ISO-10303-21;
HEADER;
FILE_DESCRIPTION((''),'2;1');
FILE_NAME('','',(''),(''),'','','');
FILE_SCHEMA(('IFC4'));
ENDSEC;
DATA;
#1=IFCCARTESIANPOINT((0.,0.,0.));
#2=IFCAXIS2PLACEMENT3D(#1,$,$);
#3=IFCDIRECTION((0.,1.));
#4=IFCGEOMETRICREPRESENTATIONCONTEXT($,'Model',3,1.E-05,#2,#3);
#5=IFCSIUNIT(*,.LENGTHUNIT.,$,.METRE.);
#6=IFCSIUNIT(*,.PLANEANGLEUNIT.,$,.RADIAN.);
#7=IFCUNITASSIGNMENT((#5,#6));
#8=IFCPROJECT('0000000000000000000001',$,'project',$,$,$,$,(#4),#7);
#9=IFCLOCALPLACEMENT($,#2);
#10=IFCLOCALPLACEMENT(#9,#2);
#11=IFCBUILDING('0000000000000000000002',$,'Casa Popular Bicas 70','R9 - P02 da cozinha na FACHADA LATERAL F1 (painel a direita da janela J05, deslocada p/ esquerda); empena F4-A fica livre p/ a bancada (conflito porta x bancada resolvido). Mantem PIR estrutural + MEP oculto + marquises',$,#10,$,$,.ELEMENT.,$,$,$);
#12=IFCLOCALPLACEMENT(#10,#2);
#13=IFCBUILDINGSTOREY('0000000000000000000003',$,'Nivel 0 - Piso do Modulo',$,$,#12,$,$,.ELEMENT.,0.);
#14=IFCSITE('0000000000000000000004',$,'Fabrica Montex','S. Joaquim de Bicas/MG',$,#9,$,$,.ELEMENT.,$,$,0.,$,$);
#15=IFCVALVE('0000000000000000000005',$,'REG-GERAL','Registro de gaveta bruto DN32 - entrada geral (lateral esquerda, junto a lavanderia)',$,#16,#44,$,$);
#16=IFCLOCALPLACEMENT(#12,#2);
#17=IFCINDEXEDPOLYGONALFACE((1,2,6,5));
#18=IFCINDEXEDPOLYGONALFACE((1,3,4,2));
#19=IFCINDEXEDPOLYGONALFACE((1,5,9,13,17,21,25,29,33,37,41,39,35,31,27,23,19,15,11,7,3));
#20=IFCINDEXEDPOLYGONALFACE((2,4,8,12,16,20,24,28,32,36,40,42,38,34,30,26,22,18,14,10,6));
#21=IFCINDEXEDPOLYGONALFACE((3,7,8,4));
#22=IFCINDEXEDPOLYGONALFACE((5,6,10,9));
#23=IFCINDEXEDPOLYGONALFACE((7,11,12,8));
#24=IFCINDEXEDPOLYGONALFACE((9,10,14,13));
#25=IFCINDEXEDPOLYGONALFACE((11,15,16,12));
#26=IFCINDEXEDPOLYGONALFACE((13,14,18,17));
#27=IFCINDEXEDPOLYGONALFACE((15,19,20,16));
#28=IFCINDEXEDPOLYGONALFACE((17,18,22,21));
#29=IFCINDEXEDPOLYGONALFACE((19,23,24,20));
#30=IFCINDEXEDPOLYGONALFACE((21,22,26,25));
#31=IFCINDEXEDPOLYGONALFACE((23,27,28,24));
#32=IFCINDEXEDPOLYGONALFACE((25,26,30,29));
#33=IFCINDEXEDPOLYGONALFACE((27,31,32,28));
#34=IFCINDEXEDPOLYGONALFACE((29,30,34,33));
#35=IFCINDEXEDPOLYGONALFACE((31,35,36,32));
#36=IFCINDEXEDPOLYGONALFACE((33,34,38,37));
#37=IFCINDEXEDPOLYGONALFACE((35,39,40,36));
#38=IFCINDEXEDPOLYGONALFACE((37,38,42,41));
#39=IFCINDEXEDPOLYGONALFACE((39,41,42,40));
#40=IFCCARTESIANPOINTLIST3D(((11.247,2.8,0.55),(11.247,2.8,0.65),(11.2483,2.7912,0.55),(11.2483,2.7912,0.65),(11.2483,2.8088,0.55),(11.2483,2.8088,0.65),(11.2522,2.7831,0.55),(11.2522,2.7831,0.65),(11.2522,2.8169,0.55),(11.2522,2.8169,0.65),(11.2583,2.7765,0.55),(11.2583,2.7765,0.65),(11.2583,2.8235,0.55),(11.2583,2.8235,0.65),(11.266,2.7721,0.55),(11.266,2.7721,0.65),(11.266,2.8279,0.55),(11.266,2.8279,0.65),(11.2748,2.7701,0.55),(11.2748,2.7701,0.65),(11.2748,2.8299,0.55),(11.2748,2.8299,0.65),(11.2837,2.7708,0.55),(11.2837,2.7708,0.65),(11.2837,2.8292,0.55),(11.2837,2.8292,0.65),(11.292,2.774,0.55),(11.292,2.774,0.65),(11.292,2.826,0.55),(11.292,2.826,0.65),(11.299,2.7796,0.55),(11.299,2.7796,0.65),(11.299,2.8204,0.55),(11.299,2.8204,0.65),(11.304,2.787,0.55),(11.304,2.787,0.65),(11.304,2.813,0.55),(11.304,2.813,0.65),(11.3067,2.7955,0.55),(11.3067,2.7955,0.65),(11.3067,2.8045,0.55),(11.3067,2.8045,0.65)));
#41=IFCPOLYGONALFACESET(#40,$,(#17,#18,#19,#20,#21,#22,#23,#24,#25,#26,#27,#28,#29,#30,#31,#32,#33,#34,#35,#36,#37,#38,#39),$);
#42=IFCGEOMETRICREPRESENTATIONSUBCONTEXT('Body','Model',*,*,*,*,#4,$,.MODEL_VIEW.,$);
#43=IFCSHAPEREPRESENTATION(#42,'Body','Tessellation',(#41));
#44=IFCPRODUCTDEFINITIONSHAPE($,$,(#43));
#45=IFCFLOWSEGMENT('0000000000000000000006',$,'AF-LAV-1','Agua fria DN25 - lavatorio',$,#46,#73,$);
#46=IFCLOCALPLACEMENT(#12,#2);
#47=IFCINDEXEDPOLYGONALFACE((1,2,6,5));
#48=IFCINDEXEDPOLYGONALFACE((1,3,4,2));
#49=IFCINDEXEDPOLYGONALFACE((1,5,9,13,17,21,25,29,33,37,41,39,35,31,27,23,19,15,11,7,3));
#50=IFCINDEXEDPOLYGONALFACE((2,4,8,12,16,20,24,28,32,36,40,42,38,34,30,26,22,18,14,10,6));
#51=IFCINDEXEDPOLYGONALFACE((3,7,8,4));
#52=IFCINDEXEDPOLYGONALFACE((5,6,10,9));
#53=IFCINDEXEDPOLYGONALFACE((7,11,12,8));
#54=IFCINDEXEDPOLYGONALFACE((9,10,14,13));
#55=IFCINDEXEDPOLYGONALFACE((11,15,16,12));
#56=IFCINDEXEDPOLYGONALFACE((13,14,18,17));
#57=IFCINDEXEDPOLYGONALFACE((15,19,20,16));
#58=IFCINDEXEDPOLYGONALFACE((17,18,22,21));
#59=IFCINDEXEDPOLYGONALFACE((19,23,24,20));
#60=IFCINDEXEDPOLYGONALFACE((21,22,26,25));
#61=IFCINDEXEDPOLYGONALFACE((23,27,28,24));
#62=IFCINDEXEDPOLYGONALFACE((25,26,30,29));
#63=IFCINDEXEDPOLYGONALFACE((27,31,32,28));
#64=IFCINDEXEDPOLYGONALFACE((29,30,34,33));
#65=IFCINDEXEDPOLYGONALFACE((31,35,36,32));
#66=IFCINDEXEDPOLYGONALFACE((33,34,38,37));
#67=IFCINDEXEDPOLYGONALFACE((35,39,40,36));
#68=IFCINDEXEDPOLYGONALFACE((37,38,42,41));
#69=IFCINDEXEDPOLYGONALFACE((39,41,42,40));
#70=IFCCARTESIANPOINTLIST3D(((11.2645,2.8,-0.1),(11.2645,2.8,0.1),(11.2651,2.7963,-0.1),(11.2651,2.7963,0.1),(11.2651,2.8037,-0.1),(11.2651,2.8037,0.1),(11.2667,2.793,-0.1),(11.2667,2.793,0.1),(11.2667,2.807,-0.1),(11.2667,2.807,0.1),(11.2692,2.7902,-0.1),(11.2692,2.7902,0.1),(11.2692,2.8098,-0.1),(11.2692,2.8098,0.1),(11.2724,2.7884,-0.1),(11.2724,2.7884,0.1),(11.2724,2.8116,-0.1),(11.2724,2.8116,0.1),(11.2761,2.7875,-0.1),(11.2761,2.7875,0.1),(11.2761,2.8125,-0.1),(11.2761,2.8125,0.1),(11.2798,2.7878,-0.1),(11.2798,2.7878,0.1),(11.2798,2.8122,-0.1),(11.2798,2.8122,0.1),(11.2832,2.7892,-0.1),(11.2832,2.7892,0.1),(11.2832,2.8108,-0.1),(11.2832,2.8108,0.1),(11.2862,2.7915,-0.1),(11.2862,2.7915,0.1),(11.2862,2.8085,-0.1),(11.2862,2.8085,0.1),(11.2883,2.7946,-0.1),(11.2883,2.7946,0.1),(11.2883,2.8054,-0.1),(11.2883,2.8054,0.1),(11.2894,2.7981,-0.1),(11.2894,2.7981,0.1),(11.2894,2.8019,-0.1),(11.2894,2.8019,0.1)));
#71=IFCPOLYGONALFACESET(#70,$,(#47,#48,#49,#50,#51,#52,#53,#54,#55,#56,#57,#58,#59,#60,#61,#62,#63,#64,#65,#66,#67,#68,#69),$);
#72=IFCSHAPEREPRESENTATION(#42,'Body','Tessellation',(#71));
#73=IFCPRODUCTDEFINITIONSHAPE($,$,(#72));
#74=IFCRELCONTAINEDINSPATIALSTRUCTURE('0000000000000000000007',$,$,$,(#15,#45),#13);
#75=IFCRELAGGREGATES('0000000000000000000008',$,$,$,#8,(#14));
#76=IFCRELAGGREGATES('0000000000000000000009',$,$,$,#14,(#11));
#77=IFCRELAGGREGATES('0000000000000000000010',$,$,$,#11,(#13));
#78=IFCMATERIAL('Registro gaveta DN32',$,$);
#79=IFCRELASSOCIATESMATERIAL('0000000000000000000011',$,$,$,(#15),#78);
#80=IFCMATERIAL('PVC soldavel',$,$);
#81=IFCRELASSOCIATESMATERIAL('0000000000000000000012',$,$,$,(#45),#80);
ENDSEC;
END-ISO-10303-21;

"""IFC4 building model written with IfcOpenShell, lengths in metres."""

from ifc_helpers import new_model, si_unit, direction, frame, origin, origin_2d, place, context, subcontext, project, spatial, circle, extrude, material, element, save


model = new_model("IFC4")

# Units and contexts
model_context = context("Model", 3, precision=1e-05, world=origin(), true_north=direction((0.0, 1.0)))
body_context = subcontext(model_context, "Body", "Model", "MODEL_VIEW")
ifc_project = project(units=[si_unit("LENGTHUNIT", "METRE"), si_unit("PLANEANGLEUNIT", "RADIAN")], contexts=[model_context])

# Site, building, storey
site_placement = place(None, origin())
site = spatial("IfcSite", under=ifc_project, at=site_placement, Name="Fabrica Montex", Description="S. Joaquim de Bicas/MG", CompositionType="ELEMENT", RefElevation=0.0)
building_placement = place(site_placement, origin())
building = spatial("IfcBuilding", under=site, at=building_placement, Name="Casa Popular Bicas 70", Description="R9 - P02 da cozinha na FACHADA LATERAL F1 (painel a direita da janela J05, deslocada p/ esquerda); empena F4-A fica livre p/ a bancada (conflito porta x bancada resolvido). Mantem PIR estrutural + MEP oculto + marquises", CompositionType="ELEMENT")
storey_placement = place(building_placement, origin())
storey = spatial("IfcBuildingStorey", under=building, at=storey_placement, Name="Nivel 0 - Piso do Modulo", CompositionType="ELEMENT", Elevation=0.0)

# Valve
ifc_material_1 = material(Name="Registro gaveta DN32")
valve_placement = place(None, frame((11.277, 2.8, 0.55), z_axis=(0.0, 0.0, 1.0), x_axis=(-1.0, 0.0, 0.0)))
element("IfcValve", 1, at=valve_placement, inside=storey, material=ifc_material_1, Name="REG-GERAL", Description="Registro de gaveta bruto DN32 - entrada geral (lateral esquerda, junto a lavanderia)", context=body_context, shape_type="SweptSolid", body=[
    extrude(circle(Radius=0.03, at=origin_2d()), origin(), (0.0, 0.0, 1.0), 0.1),
])

# Flow segment
ifc_material_2 = material(Name="PVC soldavel")
for number, where, z_axis, x_axis, name in (
    (2, (11.277, 2.8, 0.1), (0.0, 0.0, -1.0), (-1.0, 0.0, 0.0), "AF-LAV-1"),
):
    element("IfcFlowSegment", number, at=place(None, frame(where, z_axis=z_axis, x_axis=x_axis)), inside=storey, material=ifc_material_2, Name=name, Description="Agua fria DN25 - lavatorio", context=body_context, shape_type="SweptSolid", body=[
        extrude(circle(Radius=0.0125, at=origin_2d()), origin(), (0.0, 0.0, 1.0), 0.2),
    ])

save(model, "model.ifc")
